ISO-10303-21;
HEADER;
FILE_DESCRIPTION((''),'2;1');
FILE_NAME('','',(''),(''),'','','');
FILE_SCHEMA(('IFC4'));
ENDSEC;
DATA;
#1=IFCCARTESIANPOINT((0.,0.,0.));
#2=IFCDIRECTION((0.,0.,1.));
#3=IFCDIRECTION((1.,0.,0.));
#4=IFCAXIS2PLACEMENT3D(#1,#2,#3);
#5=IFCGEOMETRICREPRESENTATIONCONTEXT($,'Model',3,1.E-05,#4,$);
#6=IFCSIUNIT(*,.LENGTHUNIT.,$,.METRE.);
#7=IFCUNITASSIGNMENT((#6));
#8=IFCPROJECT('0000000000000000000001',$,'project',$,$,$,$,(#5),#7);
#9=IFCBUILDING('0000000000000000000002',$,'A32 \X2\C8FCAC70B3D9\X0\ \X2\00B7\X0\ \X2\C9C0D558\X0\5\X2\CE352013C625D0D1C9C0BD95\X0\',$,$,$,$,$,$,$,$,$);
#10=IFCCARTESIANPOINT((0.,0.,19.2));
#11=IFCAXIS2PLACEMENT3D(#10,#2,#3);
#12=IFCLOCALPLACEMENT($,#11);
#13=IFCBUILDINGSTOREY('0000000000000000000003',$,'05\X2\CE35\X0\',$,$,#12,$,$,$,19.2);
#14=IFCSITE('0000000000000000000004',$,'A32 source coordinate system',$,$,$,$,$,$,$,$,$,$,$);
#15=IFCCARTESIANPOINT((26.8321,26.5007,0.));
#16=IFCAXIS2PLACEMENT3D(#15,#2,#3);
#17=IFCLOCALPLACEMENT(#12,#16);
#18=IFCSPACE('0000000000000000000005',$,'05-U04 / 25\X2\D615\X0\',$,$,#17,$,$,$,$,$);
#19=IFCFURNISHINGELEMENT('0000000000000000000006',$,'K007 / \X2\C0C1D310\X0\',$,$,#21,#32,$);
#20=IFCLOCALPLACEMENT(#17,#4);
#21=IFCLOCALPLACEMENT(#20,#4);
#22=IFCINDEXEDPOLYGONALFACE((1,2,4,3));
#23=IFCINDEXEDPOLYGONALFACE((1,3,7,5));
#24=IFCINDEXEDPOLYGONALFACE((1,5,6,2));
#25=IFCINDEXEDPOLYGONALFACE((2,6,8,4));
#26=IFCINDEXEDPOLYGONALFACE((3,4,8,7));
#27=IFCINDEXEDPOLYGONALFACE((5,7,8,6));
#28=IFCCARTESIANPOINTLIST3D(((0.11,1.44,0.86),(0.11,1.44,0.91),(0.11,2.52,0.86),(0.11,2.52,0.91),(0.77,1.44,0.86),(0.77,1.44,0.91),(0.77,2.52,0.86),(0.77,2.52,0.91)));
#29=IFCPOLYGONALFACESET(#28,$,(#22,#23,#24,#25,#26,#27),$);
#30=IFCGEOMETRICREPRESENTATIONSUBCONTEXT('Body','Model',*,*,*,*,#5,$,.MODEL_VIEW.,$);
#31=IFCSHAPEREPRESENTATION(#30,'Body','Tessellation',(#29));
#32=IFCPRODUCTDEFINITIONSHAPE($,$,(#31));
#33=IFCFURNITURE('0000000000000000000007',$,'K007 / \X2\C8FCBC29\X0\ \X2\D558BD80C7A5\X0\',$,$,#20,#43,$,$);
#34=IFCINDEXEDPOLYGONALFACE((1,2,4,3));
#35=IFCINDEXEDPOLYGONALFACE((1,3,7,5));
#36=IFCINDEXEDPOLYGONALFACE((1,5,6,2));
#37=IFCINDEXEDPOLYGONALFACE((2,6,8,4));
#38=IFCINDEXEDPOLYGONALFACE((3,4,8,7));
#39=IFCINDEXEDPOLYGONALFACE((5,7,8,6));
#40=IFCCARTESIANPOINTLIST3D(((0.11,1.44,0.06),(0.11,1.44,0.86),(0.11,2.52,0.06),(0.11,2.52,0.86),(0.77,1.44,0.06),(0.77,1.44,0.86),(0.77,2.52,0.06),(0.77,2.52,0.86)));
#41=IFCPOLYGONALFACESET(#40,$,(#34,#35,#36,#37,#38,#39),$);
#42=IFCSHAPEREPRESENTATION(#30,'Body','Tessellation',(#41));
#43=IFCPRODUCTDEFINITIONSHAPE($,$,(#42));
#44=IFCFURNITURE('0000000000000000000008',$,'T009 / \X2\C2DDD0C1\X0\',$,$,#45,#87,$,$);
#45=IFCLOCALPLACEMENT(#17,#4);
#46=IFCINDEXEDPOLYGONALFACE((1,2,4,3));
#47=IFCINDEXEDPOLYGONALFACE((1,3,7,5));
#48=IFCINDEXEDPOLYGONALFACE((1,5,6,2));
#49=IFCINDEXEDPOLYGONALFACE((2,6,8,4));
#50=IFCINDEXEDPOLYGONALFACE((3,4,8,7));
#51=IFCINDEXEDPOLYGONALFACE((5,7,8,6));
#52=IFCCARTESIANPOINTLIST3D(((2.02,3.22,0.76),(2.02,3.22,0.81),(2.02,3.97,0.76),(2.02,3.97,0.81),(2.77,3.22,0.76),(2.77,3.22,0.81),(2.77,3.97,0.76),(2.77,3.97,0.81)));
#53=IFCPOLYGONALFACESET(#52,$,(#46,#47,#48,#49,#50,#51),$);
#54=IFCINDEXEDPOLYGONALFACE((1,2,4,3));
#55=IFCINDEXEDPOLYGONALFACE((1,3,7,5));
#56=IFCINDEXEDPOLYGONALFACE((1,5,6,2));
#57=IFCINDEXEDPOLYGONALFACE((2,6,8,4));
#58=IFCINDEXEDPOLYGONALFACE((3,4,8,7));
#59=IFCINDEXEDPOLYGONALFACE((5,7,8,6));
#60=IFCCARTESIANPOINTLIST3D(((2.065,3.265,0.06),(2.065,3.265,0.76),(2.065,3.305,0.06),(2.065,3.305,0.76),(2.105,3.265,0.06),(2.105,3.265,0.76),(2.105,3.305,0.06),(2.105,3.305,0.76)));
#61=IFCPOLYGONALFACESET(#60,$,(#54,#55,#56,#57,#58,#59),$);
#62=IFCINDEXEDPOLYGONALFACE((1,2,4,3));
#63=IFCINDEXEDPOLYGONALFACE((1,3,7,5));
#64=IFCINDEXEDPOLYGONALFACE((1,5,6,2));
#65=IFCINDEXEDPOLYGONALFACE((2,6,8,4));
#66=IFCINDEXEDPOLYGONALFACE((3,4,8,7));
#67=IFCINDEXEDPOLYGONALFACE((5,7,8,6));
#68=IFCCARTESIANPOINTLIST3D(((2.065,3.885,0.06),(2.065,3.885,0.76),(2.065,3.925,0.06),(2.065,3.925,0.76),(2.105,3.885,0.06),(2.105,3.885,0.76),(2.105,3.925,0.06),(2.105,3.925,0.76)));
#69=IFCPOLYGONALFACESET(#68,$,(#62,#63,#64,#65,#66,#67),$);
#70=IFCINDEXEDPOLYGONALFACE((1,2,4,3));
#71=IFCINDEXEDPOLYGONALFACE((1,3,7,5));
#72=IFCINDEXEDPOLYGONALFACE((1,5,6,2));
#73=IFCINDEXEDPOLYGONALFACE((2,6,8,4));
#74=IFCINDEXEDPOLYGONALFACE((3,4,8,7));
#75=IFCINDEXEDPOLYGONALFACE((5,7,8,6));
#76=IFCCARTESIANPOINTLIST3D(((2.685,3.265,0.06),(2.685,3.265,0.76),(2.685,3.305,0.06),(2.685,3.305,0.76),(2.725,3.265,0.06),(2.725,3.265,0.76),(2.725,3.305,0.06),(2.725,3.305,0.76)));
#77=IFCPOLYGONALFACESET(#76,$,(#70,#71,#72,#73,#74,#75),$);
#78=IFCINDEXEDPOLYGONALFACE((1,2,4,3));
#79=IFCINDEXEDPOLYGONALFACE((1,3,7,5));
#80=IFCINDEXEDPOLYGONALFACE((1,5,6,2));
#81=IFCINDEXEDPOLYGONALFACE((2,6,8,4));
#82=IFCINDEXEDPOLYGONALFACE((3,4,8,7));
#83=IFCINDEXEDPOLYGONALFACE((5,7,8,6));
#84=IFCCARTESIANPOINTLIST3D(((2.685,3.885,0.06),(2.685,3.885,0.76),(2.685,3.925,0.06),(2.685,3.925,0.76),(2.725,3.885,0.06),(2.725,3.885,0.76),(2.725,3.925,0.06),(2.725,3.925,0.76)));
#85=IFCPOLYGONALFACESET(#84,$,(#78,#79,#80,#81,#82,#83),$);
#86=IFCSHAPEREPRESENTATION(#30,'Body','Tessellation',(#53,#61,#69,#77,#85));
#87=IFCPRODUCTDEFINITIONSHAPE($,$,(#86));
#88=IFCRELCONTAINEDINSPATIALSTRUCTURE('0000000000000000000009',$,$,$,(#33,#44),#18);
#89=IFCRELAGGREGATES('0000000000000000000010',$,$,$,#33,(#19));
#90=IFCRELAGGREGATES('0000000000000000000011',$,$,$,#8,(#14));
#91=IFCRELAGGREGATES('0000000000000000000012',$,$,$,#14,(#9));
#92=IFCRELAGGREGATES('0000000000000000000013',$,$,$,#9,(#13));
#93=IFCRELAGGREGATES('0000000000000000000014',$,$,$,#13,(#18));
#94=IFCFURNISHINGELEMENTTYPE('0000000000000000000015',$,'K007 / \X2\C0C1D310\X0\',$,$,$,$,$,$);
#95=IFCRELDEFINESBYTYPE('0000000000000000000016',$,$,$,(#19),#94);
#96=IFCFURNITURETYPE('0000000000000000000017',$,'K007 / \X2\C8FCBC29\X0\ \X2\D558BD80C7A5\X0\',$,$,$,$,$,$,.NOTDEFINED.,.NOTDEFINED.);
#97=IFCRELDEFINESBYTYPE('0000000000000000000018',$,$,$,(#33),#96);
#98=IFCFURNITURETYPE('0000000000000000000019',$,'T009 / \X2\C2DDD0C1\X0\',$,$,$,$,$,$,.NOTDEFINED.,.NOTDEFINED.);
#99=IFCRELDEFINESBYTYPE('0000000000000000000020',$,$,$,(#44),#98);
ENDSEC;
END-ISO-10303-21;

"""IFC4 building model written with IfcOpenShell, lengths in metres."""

from ifc_helpers import new_model, si_unit, frame, origin, origin_with_axes, place, context, subcontext, project, spatial, polyline, outline, extrude, source, transform, mapped, type_object, type_shapes, element, aggregate, save


model = new_model("IFC4")

# Units and contexts
model_context = context("Model", 3, precision=1e-05, world=origin_with_axes())
body_context = subcontext(model_context, "Body", "Model", "MODEL_VIEW")
ifc_project = project(units=[si_unit("LENGTHUNIT", "METRE")], contexts=[model_context])

# Site, building, storey
site = spatial("IfcSite", under=ifc_project, Name="A32 source coordinate system")
building = spatial("IfcBuilding", under=site, Name="A32 주거동 · 지하5층–옥탑지붕")
storey_placement = place(None, frame((0.0, 0.0, 19.2), z_axis=(0.0, 0.0, 1.0), x_axis=(1.0, 0.0, 0.0)))
storey = spatial("IfcBuildingStorey", under=building, at=storey_placement, Name="05층", Elevation=19.2)

# Shared definitions
space_1_placement = place(storey_placement, frame((26.8321, 26.5007, 0.0), z_axis=(0.0, 0.0, 1.0), x_axis=(1.0, 0.0, 0.0)))
space_1 = spatial("IfcSpace", under=storey, at=space_1_placement, Name="05-U04 / 25형")

# Furnishing element
furnishing_element_type_1 = type_object("IfcFurnishingElementType", Name="K007 / 상판")
shared_shape_1 = source(origin(), body_context, "Body", "SweptSolid", [
    extrude(outline(polyline([(0.77, 2.52), (0.77, 1.44), (0.11, 1.44), (0.11, 2.52), (0.77, 2.52)])), frame((0.0, 0.0, 0.86)), (0.0, 0.0, 1.0), 0.05),
])
type_shapes(furnishing_element_type_1, [shared_shape_1])
furniture_1_placement = place(space_1_placement, origin_with_axes())
furnishing_1_placement = place(furniture_1_placement, origin_with_axes())
furnishing_1 = element("IfcFurnishingElement", 1, at=furnishing_1_placement, type_object=furnishing_element_type_1, Name="K007 / 상판", context=body_context, shape_type="MappedRepresentation", body=[
    mapped(shared_shape_1, transform((0.0, 0.0, 0.0), scale=1.0)),
])

# Furniture
furniture_type_1 = type_object("IfcFurnitureType", Name="K007 / 주방 하부장", AssemblyPlace="NOTDEFINED", PredefinedType="NOTDEFINED")
shared_shape_2 = source(origin(), body_context, "Body", "SweptSolid", [
    extrude(outline(polyline([(0.11, 2.52), (0.77, 2.52), (0.77, 1.44), (0.11, 1.44), (0.11, 2.52)])), frame((0.0, 0.0, 0.06)), (0.0, 0.0, 1.0), 0.8),
])
type_shapes(furniture_type_1, [shared_shape_2])
furniture_1 = element("IfcFurniture", 2, at=furniture_1_placement, inside=space_1, type_object=furniture_type_1, Name="K007 / 주방 하부장", context=body_context, shape_type="MappedRepresentation", body=[
    mapped(shared_shape_2, transform((0.0, 0.0, 0.0), scale=1.0)),
])
aggregate(furniture_1, [furnishing_1])
furniture_type_2 = type_object("IfcFurnitureType", Name="T009 / 식탁", AssemblyPlace="NOTDEFINED", PredefinedType="NOTDEFINED")
shared_shape_3 = source(origin(), body_context, "Body", "SweptSolid", [
    extrude(outline(polyline([(2.77, 3.22), (2.02, 3.22), (2.02, 3.97), (2.77, 3.97), (2.77, 3.22)])), frame((0.0, 0.0, 0.76)), (0.0, 0.0, 1.0), 0.05),
    extrude(outline(polyline([(2.065, 3.265), (2.065, 3.305), (2.105, 3.305), (2.105, 3.265), (2.065, 3.265)])), frame((0.0, 0.0, 0.06)), (0.0, 0.0, 1.0), 0.7),
    extrude(outline(polyline([(2.065, 3.885), (2.065, 3.925), (2.105, 3.925), (2.105, 3.885), (2.065, 3.885)])), frame((0.0, 0.0, 0.06)), (0.0, 0.0, 1.0), 0.7),
    extrude(outline(polyline([(2.685, 3.265), (2.685, 3.305), (2.725, 3.305), (2.725, 3.265), (2.685, 3.265)])), frame((0.0, 0.0, 0.06)), (0.0, 0.0, 1.0), 0.7),
    extrude(outline(polyline([(2.685, 3.885), (2.685, 3.925), (2.725, 3.925), (2.725, 3.885), (2.685, 3.885)])), frame((0.0, 0.0, 0.06)), (0.0, 0.0, 1.0), 0.7),
])
type_shapes(furniture_type_2, [shared_shape_3])
furniture_2_placement = place(space_1_placement, origin_with_axes())
element("IfcFurniture", 3, at=furniture_2_placement, inside=space_1, type_object=furniture_type_2, Name="T009 / 식탁", context=body_context, shape_type="MappedRepresentation", body=[
    mapped(shared_shape_3, transform((0.0, 0.0, 0.0), scale=1.0)),
])

save(model, "model.ifc")
